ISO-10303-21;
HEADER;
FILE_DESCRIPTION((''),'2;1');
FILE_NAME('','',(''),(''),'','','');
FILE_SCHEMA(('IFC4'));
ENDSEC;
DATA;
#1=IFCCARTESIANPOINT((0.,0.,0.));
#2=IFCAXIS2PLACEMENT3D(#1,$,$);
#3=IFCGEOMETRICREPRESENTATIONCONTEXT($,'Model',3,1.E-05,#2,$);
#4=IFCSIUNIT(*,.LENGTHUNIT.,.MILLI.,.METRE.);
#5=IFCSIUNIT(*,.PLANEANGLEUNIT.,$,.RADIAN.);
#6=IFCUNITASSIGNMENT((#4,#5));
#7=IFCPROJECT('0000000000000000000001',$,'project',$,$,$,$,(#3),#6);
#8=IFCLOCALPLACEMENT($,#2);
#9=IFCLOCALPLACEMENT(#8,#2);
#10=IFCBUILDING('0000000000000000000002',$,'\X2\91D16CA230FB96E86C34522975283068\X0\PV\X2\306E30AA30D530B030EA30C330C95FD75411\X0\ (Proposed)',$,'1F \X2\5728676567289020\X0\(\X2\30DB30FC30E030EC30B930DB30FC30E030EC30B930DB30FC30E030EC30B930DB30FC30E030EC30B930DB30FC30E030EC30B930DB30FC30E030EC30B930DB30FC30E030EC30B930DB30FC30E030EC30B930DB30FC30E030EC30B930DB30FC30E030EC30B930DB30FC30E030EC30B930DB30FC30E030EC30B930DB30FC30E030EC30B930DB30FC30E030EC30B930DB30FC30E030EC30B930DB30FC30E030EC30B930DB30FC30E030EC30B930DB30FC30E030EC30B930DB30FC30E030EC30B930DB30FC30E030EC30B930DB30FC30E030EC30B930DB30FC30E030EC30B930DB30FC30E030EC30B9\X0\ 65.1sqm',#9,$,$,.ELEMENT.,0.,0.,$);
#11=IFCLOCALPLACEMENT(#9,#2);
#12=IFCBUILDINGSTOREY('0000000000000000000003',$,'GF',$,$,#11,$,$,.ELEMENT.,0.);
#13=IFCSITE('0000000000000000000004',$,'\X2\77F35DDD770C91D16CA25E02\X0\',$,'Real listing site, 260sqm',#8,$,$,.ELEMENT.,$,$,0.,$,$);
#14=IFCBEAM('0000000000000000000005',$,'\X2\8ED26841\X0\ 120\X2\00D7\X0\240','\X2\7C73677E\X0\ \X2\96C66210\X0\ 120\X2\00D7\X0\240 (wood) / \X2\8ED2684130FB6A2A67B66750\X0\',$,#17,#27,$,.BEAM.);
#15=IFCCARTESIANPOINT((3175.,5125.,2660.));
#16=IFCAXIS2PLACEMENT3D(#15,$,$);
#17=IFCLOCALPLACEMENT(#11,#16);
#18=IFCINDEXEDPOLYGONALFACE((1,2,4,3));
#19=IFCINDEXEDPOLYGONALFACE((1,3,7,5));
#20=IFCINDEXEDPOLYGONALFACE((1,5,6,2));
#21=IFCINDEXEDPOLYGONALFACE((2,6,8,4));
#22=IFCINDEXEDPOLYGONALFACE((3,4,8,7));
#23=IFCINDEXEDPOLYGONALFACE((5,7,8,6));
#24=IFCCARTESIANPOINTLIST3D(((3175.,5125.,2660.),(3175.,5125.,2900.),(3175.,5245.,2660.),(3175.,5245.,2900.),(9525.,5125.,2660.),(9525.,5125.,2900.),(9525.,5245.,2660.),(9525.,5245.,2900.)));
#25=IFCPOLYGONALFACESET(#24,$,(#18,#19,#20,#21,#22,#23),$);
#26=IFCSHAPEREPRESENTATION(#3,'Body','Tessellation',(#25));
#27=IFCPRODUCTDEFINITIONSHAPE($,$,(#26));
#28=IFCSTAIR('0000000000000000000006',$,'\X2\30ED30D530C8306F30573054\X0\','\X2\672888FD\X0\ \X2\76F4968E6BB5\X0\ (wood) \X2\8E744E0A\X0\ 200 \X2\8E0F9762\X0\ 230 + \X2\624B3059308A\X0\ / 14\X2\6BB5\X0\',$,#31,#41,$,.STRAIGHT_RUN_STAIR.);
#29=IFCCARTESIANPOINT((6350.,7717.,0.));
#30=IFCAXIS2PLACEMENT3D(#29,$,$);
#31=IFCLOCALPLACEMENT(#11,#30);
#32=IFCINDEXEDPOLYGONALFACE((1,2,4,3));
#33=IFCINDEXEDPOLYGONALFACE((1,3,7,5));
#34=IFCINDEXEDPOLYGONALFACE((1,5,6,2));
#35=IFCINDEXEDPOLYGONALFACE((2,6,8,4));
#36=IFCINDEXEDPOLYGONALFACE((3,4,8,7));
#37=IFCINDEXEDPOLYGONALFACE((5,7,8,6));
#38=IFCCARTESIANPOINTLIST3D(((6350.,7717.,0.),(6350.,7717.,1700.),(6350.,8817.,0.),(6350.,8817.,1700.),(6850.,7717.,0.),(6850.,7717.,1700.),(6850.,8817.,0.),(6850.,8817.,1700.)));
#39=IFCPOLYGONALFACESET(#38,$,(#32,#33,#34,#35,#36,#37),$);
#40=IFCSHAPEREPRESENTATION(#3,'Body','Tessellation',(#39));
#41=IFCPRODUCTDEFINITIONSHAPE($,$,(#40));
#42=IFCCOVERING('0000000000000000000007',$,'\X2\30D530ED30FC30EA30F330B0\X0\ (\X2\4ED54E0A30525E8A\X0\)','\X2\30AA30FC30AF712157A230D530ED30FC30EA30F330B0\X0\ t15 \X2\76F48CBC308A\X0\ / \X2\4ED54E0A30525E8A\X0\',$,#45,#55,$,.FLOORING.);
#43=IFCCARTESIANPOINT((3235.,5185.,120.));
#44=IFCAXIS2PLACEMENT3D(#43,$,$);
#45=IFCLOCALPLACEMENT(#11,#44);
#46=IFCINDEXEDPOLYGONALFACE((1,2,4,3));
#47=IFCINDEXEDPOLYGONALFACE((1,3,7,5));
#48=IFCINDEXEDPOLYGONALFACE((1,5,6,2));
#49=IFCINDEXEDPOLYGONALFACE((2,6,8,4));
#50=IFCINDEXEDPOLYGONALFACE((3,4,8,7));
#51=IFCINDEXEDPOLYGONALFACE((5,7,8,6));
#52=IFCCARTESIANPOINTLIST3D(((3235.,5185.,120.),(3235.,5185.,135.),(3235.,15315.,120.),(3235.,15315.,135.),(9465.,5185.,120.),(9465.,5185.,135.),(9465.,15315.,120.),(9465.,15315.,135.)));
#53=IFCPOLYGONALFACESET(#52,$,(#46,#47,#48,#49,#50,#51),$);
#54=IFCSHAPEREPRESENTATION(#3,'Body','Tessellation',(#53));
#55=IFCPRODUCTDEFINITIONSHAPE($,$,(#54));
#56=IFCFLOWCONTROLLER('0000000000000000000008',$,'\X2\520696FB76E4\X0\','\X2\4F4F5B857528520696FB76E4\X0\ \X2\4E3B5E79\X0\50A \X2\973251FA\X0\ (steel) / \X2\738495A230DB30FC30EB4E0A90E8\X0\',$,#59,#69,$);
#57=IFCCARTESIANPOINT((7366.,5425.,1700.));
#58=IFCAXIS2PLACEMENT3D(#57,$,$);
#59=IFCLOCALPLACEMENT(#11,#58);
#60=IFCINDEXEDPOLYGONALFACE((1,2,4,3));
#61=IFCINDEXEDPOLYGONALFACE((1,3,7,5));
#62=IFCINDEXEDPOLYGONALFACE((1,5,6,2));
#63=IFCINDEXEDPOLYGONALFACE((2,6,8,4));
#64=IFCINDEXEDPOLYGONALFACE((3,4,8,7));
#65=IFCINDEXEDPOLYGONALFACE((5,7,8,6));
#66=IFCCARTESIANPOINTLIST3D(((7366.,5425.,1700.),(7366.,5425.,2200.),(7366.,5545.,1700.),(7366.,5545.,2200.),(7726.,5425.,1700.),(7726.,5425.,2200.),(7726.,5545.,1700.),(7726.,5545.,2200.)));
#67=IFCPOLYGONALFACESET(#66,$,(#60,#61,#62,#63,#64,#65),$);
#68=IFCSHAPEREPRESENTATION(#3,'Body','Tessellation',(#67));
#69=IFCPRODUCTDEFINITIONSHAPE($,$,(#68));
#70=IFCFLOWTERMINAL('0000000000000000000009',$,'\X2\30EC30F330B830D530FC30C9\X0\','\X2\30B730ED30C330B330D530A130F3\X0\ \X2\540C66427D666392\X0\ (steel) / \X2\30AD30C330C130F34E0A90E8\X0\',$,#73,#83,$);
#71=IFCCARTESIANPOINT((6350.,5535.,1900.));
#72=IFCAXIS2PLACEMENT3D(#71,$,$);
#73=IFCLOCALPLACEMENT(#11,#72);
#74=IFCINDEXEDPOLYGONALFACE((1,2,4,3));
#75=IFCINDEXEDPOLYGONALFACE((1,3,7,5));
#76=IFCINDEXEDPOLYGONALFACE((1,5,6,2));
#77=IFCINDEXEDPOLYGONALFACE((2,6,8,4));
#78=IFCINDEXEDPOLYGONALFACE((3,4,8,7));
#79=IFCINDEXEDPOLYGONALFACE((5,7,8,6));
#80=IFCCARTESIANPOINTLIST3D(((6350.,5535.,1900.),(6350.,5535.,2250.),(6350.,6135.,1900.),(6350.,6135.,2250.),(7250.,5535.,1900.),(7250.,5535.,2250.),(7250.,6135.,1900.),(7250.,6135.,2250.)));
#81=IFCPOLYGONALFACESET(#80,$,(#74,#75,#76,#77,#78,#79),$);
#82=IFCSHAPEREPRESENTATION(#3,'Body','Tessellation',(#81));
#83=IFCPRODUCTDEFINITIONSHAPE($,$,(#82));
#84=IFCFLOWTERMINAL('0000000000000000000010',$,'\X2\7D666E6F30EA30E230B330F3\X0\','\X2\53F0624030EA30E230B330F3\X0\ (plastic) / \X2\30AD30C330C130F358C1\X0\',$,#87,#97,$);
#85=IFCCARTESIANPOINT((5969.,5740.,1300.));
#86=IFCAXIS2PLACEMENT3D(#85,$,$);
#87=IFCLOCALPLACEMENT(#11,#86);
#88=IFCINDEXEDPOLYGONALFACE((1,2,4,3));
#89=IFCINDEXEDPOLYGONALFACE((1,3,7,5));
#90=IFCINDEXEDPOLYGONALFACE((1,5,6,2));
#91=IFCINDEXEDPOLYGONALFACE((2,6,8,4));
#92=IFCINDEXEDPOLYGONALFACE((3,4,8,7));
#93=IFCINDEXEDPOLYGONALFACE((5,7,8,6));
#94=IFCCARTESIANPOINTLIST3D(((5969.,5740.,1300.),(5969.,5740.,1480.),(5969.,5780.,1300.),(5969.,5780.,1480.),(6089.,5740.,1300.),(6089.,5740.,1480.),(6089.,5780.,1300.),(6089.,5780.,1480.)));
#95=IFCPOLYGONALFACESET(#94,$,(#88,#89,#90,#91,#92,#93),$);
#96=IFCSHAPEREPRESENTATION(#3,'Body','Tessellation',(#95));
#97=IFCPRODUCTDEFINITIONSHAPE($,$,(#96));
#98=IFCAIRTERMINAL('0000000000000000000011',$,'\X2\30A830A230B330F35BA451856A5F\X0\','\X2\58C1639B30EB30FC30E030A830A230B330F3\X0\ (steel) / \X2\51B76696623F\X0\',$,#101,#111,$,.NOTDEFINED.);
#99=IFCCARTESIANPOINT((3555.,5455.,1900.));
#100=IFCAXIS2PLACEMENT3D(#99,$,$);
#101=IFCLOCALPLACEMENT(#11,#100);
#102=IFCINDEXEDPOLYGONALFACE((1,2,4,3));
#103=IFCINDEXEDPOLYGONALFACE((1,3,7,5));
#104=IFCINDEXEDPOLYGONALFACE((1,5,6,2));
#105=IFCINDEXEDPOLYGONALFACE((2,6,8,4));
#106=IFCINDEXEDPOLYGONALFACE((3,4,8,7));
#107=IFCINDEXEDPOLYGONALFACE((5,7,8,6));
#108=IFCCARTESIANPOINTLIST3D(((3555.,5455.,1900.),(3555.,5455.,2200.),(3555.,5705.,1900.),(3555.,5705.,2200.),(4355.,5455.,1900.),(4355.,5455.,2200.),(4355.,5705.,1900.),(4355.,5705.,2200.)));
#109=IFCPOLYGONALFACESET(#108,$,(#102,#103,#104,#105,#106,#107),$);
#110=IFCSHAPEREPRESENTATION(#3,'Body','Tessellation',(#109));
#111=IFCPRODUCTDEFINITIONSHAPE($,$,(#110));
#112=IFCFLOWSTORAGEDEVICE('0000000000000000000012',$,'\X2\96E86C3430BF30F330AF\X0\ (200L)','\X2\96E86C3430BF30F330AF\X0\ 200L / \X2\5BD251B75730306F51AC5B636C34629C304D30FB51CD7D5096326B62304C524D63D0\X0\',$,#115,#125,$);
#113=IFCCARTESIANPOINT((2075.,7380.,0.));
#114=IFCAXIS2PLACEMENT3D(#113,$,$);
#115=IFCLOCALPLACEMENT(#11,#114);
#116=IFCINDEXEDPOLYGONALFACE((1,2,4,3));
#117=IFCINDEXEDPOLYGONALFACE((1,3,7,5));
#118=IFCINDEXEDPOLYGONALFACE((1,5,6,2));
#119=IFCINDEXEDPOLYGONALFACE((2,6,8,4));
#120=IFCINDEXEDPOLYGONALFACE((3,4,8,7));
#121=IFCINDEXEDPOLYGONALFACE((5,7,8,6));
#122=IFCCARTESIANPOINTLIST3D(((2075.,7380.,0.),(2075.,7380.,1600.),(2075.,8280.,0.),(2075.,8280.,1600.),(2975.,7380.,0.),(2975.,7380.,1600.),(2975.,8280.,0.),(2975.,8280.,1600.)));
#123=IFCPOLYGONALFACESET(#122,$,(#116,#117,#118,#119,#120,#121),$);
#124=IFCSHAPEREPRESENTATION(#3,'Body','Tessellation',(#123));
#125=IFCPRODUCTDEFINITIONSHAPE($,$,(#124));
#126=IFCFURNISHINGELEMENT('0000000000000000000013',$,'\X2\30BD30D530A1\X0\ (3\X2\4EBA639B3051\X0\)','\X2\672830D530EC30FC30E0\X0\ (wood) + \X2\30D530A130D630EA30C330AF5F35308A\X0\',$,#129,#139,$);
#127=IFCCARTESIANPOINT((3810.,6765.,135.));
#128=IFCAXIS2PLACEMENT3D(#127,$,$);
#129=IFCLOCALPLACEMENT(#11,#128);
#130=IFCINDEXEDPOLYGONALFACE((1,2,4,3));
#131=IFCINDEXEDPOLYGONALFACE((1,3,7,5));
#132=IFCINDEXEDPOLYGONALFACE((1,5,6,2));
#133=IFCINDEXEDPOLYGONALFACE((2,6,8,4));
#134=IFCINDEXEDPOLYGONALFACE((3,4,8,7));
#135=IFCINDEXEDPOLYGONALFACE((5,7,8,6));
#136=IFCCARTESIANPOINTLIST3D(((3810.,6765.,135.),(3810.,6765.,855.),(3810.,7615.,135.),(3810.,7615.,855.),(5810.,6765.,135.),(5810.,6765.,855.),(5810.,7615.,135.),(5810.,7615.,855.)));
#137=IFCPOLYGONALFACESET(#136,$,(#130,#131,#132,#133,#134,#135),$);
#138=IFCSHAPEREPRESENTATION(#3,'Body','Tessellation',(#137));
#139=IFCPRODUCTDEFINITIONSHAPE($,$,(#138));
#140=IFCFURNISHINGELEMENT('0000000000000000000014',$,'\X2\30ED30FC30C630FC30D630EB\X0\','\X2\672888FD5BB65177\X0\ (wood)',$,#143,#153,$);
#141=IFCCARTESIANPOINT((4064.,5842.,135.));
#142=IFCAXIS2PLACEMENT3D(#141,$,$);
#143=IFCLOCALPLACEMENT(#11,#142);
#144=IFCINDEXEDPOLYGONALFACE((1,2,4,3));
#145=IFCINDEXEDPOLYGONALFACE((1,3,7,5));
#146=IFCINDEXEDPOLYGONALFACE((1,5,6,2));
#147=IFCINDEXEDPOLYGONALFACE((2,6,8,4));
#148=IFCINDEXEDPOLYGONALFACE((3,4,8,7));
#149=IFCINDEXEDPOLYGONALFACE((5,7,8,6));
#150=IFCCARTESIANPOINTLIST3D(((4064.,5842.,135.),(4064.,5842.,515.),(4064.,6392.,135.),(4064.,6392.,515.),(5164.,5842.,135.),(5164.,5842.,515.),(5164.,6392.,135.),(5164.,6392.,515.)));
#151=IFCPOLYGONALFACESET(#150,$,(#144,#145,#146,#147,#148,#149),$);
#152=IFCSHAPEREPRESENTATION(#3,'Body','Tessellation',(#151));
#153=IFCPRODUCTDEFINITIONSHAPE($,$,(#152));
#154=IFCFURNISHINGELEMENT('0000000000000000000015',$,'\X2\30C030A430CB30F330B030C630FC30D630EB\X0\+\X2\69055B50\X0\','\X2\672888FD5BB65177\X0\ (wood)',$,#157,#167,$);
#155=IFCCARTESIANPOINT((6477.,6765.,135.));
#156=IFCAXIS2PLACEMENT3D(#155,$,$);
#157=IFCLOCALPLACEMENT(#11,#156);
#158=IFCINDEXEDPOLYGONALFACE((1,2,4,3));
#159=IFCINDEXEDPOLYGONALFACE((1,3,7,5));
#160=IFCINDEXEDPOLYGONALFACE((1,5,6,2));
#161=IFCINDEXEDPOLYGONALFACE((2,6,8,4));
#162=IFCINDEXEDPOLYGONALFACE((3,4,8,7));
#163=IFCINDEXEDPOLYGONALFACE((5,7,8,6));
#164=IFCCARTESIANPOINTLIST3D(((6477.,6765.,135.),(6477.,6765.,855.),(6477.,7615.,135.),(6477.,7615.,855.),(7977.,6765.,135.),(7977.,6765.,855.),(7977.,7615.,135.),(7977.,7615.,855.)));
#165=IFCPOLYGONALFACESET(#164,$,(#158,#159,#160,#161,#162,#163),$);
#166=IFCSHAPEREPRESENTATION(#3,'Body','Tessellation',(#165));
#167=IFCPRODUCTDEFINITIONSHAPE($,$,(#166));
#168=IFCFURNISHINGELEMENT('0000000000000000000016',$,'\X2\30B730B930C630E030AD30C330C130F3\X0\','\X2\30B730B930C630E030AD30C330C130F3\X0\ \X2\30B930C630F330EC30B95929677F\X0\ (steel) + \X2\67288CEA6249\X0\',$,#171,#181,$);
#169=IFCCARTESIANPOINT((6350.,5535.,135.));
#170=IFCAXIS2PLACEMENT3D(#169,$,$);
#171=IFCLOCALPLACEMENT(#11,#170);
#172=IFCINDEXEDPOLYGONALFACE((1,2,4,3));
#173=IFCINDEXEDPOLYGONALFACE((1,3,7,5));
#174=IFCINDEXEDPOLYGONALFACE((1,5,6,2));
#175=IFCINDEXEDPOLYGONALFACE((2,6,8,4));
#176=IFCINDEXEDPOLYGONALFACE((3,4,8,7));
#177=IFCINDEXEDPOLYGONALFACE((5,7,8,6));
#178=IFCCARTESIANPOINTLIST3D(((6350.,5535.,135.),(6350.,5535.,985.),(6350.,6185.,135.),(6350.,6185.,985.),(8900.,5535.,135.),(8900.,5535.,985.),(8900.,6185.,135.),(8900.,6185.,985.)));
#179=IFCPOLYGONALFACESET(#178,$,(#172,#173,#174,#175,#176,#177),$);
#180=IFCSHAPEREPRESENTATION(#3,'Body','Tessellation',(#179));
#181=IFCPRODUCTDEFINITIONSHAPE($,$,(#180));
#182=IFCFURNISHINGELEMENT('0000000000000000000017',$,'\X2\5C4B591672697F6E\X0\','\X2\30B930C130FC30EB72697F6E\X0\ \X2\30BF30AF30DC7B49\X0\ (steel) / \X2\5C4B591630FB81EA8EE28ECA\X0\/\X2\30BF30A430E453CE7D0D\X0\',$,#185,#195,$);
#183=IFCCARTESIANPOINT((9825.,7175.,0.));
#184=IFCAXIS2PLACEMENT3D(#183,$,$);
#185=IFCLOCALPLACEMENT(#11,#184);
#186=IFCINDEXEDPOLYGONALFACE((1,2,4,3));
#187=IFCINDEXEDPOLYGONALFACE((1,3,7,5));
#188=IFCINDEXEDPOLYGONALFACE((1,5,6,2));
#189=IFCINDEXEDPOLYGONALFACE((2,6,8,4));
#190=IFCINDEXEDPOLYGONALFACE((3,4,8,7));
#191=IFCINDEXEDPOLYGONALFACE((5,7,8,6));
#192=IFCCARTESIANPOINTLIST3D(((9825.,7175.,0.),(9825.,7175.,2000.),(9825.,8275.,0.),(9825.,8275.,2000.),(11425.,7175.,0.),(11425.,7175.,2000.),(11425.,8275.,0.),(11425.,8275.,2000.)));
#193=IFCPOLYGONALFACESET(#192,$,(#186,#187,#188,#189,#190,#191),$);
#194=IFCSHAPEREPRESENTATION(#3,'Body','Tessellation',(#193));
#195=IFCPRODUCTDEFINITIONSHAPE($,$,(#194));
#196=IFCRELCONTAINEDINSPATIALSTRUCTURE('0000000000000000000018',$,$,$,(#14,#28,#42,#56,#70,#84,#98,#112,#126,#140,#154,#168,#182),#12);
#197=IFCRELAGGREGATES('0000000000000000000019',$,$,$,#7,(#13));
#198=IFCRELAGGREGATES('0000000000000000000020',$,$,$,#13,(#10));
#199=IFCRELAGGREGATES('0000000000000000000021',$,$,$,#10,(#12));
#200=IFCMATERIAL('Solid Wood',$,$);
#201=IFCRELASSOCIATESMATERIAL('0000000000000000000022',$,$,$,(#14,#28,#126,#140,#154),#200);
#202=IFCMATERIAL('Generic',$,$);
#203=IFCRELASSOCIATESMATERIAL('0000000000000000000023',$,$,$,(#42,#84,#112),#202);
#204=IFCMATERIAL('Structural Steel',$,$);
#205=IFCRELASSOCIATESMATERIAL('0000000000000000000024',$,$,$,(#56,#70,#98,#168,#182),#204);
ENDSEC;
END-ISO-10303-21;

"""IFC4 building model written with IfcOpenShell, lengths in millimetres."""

from ifc_helpers import new_model, si_unit, frame, frame_2d, origin, place, context, project, spatial, rectangle, extrude, material, element, save


model = new_model("IFC4")

# Units and contexts
model_context = context("Model", 3, precision=1e-05, world=origin())
ifc_project = project(units=[si_unit("LENGTHUNIT", "METRE", prefix="MILLI"), si_unit("PLANEANGLEUNIT", "RADIAN")], contexts=[model_context])

# Site, building, storey
site_placement = place(None, origin())
site = spatial("IfcSite", under=ifc_project, at=site_placement, Name="石川県金沢市", ObjectType="Real listing site, 260sqm", CompositionType="ELEMENT", RefElevation=0.0)
building_placement = place(site_placement, origin())
building = spatial("IfcBuilding", under=site, at=building_placement, Name="金沢・雨水利用とPVのオフグリッド志向 (Proposed)", ObjectType="1F 在来木造(ホームレスホームレスホームレスホームレスホームレスホームレスホームレスホームレスホームレスホームレスホームレスホームレスホームレスホームレスホームレスホームレスホームレスホームレスホームレスホームレスホームレスホームレスホームレス 65.1sqm", CompositionType="ELEMENT", ElevationOfRefHeight=0.0, ElevationOfTerrain=0.0)
storey_placement = place(building_placement, origin())
storey = spatial("IfcBuildingStorey", under=building, at=storey_placement, Name="GF", CompositionType="ELEMENT", Elevation=0.0)

# Beam
ifc_material_1 = material(Name="Solid Wood")
beam_1_placement = place(storey_placement, frame((3175.0, 5125.0, 2660.0)))
element("IfcBeam", 1, at=beam_1_placement, inside=storey, material=ifc_material_1, Name="軒桁 120×240", Description="米松 集成 120×240 (wood) / 軒桁・横架材", PredefinedType="BEAM", context=model_context, shape_type="SweptSolid", body=[
    extrude(rectangle(XDim=6350.0, YDim=120.0, at=frame_2d((3175.0, 60.0))), frame((3175.0, 5125.0, 2660.0)), (0.0, 0.0, 1.0), 240.0),
])

# Stair
stair_placement = place(storey_placement, frame((6350.0, 7717.0, 0.0)))
element("IfcStair", 2, at=stair_placement, inside=storey, material=ifc_material_1, Name="ロフトはしご", Description="木製 直階段 (wood) 蹴上 200 踏面 230 + 手すり / 14段", PredefinedType="STRAIGHT_RUN_STAIR", context=model_context, shape_type="SweptSolid", body=[
    extrude(rectangle(XDim=500.0, YDim=1100.0, at=frame_2d((250.0, 550.0))), frame((6350.0, 7717.0, 0.0)), (0.0, 0.0, 1.0), 1700.0),
])

# Covering
ifc_material_2 = material(Name="Generic")
covering_placement = place(storey_placement, frame((3235.0, 5185.0, 120.0)))
element("IfcCovering", 3, at=covering_placement, inside=storey, material=ifc_material_2, Name="フローリング (仕上げ床)", Description="オーク無垢フローリング t15 直貼り / 仕上げ床", PredefinedType="FLOORING", context=model_context, shape_type="SweptSolid", body=[
    extrude(rectangle(XDim=6230.0, YDim=10130.0, at=frame_2d((3115.0, 5065.0))), frame((3235.0, 5185.0, 120.0)), (0.0, 0.0, 1.0), 15.0),
])

# Flow controller
ifc_material_3 = material(Name="Structural Steel")
flow_controller_placement = place(storey_placement, frame((7366.0, 5425.0, 1700.0)))
element("IfcFlowController", 4, at=flow_controller_placement, inside=storey, material=ifc_material_3, Name="分電盤", Description="住宅用分電盤 主幹50A 露出 (steel) / 玄関ホール上部", context=model_context, shape_type="SweptSolid", body=[
    extrude(rectangle(XDim=360.0, YDim=120.0, at=frame_2d((180.0, 60.0))), frame((7366.0, 5425.0, 1700.0)), (0.0, 0.0, 1.0), 500.0),
])

# Flow terminals
flow_terminal_1_placement = place(storey_placement, frame((6350.0, 5535.0, 1900.0)))
element("IfcFlowTerminal", 5, at=flow_terminal_1_placement, inside=storey, material=ifc_material_3, Name="レンジフード", Description="シロッコファン 同時給排 (steel) / キッチン上部", context=model_context, shape_type="SweptSolid", body=[
    extrude(rectangle(XDim=900.0, YDim=600.0, at=frame_2d((450.0, 300.0))), frame((6350.0, 5535.0, 1900.0)), (0.0, 0.0, 1.0), 350.0),
])
flow_terminal_2_placement = place(storey_placement, frame((5969.0, 5740.0, 1300.0)))
element("IfcFlowTerminal", 6, at=flow_terminal_2_placement, inside=storey, material=ifc_material_2, Name="給湯リモコン", Description="台所リモコン (plastic) / キッチン壁", context=model_context, shape_type="SweptSolid", body=[
    extrude(rectangle(XDim=120.0, YDim=40.0, at=frame_2d((60.0, 20.0))), frame((5969.0, 5740.0, 1300.0)), (0.0, 0.0, 1.0), 180.0),
])

# Air terminal
air_terminal_placement = place(storey_placement, frame((3555.0, 5455.0, 1900.0)))
element("IfcAirTerminal", 7, at=air_terminal_placement, inside=storey, material=ifc_material_3, Name="エアコン室内機", Description="壁掛ルームエアコン (steel) / 冷暖房", PredefinedType="NOTDEFINED", context=model_context, shape_type="SweptSolid", body=[
    extrude(rectangle(XDim=800.0, YDim=250.0, at=frame_2d((400.0, 125.0))), frame((3555.0, 5455.0, 1900.0)), (0.0, 0.0, 1.0), 300.0),
])

# Flow storage device
flow_storage_device_placement = place(storey_placement, frame((2075.0, 7380.0, 0.0)))
element("IfcFlowStorageDevice", 8, at=flow_storage_device_placement, inside=storey, material=ifc_material_2, Name="雨水タンク (200L)", Description="雨水タンク 200L / 寒冷地は冬季水抜き・凍結防止が前提", context=model_context, shape_type="SweptSolid", body=[
    extrude(rectangle(XDim=900.0, YDim=900.0, at=frame_2d((450.0, 450.0))), frame((2075.0, 7380.0, 0.0)), (0.0, 0.0, 1.0), 1600.0),
])

# Furnishing elements
furnishing_1_placement = place(storey_placement, frame((3810.0, 6765.0, 135.0)))
element("IfcFurnishingElement", 9, at=furnishing_1_placement, inside=storey, material=ifc_material_1, Name="ソファ (3人掛け)", Description="木フレーム (wood) + ファブリック張り", context=model_context, shape_type="SweptSolid", body=[
    extrude(rectangle(XDim=2000.0, YDim=850.0, at=frame_2d((1000.0, 425.0))), frame((3810.0, 6765.0, 135.0)), (0.0, 0.0, 1.0), 720.0),
])
furnishing_2_placement = place(storey_placement, frame((4064.0, 5842.0, 135.0)))
element("IfcFurnishingElement", 10, at=furnishing_2_placement, inside=storey, material=ifc_material_1, Name="ローテーブル", Description="木製家具 (wood)", context=model_context, shape_type="SweptSolid", body=[
    extrude(rectangle(XDim=1100.0, YDim=550.0, at=frame_2d((550.0, 275.0))), frame((4064.0, 5842.0, 135.0)), (0.0, 0.0, 1.0), 380.0),
])
furnishing_3_placement = place(storey_placement, frame((6477.0, 6765.0, 135.0)))
element("IfcFurnishingElement", 11, at=furnishing_3_placement, inside=storey, material=ifc_material_1, Name="ダイニングテーブル+椅子", Description="木製家具 (wood)", context=model_context, shape_type="SweptSolid", body=[
    extrude(rectangle(XDim=1500.0, YDim=850.0, at=frame_2d((750.0, 425.0))), frame((6477.0, 6765.0, 135.0)), (0.0, 0.0, 1.0), 720.0),
])
furnishing_4_placement = place(storey_placement, frame((6350.0, 5535.0, 135.0)))
element("IfcFurnishingElement", 12, at=furnishing_4_placement, inside=storey, material=ifc_material_3, Name="システムキッチン", Description="システムキッチン ステンレス天板 (steel) + 木質扉", context=model_context, shape_type="SweptSolid", body=[
    extrude(rectangle(XDim=2550.0, YDim=650.0, at=frame_2d((1275.0, 325.0))), frame((6350.0, 5535.0, 135.0)), (0.0, 0.0, 1.0), 850.0),
])
furnishing_5_placement = place(storey_placement, frame((9825.0, 7175.0, 0.0)))
element("IfcFurnishingElement", 13, at=furnishing_5_placement, inside=storey, material=ifc_material_3, Name="屋外物置", Description="スチール物置 タクボ等 (steel) / 屋外・自転車/タイヤ収納", context=model_context, shape_type="SweptSolid", body=[
    extrude(rectangle(XDim=1600.0, YDim=1100.0, at=frame_2d((800.0, 550.0))), frame((9825.0, 7175.0, 0.0)), (0.0, 0.0, 1.0), 2000.0),
])

save(model, "model.ifc")
